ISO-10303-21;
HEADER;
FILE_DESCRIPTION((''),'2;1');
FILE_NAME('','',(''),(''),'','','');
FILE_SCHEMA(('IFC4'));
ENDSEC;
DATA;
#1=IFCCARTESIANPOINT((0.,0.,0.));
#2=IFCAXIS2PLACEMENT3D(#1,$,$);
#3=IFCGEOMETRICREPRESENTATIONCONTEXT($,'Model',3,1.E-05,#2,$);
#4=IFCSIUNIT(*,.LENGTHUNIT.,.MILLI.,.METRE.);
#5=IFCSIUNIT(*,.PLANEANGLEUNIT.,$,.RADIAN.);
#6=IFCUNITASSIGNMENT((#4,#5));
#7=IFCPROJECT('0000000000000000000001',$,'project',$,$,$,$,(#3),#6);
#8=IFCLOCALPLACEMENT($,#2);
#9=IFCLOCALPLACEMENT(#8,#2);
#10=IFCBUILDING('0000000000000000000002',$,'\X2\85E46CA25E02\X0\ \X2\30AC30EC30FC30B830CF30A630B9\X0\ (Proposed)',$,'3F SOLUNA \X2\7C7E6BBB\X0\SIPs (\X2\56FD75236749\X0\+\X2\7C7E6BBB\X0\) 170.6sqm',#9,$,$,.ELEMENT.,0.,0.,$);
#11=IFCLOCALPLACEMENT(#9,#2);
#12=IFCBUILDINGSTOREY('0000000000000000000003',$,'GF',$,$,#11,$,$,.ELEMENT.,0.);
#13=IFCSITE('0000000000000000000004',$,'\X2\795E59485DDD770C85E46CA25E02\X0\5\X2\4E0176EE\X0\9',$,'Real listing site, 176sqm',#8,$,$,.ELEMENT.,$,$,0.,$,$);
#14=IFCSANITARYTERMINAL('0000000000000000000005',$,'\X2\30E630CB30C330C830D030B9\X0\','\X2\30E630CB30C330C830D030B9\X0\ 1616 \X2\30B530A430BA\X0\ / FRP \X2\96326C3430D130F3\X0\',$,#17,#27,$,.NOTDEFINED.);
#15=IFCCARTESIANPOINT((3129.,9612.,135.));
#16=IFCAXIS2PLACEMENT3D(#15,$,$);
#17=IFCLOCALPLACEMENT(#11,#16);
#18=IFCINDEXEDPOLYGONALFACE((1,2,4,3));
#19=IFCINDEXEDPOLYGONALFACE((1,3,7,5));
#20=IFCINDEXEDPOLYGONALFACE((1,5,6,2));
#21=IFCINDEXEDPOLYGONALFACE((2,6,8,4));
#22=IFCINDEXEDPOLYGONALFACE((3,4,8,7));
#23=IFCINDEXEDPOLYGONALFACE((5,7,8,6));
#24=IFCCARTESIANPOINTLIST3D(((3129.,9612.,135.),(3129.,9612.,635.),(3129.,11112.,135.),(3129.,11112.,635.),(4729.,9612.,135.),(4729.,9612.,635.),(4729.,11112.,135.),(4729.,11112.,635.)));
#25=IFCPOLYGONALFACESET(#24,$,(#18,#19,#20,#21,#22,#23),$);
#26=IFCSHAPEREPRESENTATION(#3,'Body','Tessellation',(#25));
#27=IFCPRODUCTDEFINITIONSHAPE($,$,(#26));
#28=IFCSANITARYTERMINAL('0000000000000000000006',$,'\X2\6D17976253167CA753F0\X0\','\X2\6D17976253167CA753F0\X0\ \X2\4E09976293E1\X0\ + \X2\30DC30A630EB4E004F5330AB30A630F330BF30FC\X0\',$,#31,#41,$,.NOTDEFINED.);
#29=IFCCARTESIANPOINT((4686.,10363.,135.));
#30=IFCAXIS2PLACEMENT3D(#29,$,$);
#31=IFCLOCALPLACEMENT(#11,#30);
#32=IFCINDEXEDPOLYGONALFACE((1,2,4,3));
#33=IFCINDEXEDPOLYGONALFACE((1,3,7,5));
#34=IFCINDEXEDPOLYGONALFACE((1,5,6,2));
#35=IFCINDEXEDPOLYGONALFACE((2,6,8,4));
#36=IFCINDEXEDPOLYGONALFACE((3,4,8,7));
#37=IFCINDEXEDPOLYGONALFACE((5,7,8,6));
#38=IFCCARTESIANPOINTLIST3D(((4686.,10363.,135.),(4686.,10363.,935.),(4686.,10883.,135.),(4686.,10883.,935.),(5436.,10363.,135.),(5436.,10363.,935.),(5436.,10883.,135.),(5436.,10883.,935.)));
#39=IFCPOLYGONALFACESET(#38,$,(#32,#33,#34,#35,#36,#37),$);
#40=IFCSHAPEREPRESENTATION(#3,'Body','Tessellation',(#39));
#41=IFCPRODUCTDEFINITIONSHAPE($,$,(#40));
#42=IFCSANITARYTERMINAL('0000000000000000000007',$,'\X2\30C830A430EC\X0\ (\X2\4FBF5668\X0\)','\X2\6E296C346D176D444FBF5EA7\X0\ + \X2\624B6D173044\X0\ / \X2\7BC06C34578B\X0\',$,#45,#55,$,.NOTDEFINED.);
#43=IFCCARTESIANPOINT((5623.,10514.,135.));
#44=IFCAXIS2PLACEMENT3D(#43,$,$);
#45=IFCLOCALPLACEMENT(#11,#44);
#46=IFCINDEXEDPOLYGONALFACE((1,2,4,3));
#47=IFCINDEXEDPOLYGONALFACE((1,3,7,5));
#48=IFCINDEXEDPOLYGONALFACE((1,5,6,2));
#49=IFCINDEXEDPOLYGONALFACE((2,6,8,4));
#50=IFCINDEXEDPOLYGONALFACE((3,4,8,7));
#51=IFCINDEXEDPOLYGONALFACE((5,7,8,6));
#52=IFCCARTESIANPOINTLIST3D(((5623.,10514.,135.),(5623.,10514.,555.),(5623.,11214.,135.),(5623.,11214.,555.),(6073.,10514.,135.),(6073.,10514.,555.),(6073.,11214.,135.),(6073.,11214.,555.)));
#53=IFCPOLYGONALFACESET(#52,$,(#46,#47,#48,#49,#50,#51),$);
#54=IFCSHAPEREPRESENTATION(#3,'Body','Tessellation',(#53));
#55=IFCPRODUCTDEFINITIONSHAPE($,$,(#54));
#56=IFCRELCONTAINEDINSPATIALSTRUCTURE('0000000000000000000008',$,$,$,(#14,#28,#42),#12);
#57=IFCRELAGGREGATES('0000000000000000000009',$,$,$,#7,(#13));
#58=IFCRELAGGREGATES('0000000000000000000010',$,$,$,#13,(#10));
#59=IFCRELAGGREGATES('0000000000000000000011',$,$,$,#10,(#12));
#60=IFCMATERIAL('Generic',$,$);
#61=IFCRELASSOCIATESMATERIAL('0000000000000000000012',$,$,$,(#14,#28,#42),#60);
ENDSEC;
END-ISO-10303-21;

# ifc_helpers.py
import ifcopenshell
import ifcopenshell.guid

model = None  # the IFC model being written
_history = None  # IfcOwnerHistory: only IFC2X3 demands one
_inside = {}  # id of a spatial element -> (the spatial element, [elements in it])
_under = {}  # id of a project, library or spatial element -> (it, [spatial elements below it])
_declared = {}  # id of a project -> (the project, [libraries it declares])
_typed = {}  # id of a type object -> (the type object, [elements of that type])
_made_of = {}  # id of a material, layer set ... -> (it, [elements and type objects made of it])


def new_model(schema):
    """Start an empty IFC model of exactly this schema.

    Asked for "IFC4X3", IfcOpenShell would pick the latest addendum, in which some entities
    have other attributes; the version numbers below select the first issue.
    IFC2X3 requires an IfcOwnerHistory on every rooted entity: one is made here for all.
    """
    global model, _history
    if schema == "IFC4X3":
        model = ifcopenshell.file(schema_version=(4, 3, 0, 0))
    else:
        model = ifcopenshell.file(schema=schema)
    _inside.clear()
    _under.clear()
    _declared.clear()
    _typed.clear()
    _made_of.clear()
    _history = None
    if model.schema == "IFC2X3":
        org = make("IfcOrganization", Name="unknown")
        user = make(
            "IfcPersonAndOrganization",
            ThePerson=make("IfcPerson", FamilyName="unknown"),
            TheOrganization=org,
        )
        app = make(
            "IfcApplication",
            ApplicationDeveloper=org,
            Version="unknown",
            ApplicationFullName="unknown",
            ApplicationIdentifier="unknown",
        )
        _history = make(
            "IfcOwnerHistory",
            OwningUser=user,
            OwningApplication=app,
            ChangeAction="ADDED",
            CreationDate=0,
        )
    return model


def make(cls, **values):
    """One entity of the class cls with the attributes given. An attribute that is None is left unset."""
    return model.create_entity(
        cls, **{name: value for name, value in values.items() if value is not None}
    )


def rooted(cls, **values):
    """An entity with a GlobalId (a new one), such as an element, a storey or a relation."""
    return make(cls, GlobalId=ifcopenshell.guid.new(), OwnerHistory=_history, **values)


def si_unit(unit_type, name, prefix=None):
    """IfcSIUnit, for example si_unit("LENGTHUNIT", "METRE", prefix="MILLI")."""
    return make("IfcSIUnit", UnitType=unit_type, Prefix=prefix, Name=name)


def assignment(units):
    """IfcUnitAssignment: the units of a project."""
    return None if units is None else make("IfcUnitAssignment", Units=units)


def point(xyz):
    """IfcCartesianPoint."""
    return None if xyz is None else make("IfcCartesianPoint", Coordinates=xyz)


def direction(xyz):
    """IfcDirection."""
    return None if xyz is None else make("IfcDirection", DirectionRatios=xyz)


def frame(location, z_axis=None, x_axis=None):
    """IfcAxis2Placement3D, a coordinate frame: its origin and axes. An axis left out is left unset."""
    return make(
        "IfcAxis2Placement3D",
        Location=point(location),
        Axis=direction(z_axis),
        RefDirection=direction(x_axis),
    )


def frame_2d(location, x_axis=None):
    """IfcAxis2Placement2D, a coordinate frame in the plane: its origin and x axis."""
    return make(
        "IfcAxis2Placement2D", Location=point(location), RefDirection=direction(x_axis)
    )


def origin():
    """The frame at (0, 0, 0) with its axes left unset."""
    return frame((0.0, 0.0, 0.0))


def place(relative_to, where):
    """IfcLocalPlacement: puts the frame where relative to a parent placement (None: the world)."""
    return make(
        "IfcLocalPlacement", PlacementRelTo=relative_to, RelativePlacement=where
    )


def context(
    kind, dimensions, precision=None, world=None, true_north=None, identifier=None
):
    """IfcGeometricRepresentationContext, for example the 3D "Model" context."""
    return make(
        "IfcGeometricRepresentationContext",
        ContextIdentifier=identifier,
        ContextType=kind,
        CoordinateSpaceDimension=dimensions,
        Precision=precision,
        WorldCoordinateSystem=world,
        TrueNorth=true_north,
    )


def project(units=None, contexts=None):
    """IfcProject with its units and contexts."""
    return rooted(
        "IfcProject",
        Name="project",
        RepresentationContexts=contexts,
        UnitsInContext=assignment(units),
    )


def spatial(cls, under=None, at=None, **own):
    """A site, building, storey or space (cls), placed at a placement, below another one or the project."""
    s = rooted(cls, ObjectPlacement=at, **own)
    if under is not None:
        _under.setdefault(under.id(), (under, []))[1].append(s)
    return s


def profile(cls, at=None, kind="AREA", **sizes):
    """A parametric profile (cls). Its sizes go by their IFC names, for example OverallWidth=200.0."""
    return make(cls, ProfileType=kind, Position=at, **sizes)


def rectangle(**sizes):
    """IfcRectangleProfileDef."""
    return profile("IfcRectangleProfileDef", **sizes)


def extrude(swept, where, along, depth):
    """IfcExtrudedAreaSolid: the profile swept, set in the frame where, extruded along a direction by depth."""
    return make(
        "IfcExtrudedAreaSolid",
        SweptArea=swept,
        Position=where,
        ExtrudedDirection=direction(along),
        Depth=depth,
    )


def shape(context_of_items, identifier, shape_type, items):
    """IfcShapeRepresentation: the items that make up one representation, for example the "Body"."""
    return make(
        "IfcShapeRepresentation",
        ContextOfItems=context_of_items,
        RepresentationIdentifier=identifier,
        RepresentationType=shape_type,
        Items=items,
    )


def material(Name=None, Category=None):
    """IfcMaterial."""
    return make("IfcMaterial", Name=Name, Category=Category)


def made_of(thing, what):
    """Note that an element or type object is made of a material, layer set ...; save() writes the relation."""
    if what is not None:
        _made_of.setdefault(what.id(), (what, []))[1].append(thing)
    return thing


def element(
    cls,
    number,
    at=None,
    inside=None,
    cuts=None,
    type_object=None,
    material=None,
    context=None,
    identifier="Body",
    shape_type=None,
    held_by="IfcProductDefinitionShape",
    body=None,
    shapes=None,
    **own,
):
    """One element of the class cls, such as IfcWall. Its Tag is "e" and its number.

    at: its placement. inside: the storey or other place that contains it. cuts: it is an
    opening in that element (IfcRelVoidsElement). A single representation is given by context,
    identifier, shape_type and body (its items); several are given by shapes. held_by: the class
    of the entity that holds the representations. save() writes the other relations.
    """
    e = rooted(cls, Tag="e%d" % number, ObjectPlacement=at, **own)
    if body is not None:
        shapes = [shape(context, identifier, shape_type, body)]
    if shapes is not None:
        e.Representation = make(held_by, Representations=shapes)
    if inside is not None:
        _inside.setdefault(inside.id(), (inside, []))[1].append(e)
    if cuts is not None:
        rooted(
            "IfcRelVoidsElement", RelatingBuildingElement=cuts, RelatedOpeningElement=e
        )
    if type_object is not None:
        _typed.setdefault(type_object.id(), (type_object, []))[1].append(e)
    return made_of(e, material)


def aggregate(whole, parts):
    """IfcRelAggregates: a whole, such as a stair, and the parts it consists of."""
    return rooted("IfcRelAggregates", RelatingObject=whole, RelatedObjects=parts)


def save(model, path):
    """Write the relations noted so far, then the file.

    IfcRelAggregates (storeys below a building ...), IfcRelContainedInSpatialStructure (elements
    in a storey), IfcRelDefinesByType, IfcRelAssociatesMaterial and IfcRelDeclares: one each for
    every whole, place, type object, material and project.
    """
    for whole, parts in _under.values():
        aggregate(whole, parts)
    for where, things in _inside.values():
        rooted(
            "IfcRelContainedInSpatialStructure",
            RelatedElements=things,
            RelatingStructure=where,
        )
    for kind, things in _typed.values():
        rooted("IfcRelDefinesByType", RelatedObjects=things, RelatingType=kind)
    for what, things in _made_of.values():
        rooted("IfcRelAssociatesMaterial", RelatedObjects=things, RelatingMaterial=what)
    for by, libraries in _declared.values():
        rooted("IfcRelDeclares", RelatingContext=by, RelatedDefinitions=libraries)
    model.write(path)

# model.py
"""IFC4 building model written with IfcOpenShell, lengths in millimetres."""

from ifc_helpers import new_model, si_unit, frame, frame_2d, origin, place, context, project, spatial, rectangle, extrude, material, element, save


model = new_model("IFC4")

# Units and contexts
model_context = context("Model", 3, precision=1e-05, world=origin())
ifc_project = project(units=[si_unit("LENGTHUNIT", "METRE", prefix="MILLI"), si_unit("PLANEANGLEUNIT", "RADIAN")], contexts=[model_context])

# Site, building, storey
site_placement = place(None, origin())
site = spatial("IfcSite", under=ifc_project, at=site_placement, Name="神奈川県藤沢市5丁目9", ObjectType="Real listing site, 176sqm", CompositionType="ELEMENT", RefElevation=0.0)
building_placement = place(site_placement, origin())
building = spatial("IfcBuilding", under=site, at=building_placement, Name="藤沢市 ガレージハウス (Proposed)", ObjectType="3F SOLUNA 籾殻SIPs (国産杉+籾殻) 170.6sqm", CompositionType="ELEMENT", ElevationOfRefHeight=0.0, ElevationOfTerrain=0.0)
storey_placement = place(building_placement, origin())
storey = spatial("IfcBuildingStorey", under=building, at=storey_placement, Name="GF", CompositionType="ELEMENT", Elevation=0.0)

# Shared definitions
ifc_material_1 = material(Name="Generic")

# Sanitary terminals
sanitary_terminal_1_placement = place(storey_placement, frame((3129.0, 9612.0, 135.0)))
element("IfcSanitaryTerminal", 1, at=sanitary_terminal_1_placement, inside=storey, material=ifc_material_1, Name="ユニットバス", Description="ユニットバス 1616 サイズ / FRP 防水パン", PredefinedType="NOTDEFINED", context=model_context, shape_type="SweptSolid", body=[
    extrude(rectangle(XDim=1600.0, YDim=1500.0, at=frame_2d((800.0, 750.0))), frame((3129.0, 9612.0, 135.0)), (0.0, 0.0, 1.0), 500.0),
])
sanitary_terminal_2_placement = place(storey_placement, frame((4686.0, 10363.0, 135.0)))
element("IfcSanitaryTerminal", 2, at=sanitary_terminal_2_placement, inside=storey, material=ifc_material_1, Name="洗面化粧台", Description="洗面化粧台 三面鏡 + ボウル一体カウンター", PredefinedType="NOTDEFINED", context=model_context, shape_type="SweptSolid", body=[
    extrude(rectangle(XDim=750.0, YDim=520.0, at=frame_2d((375.0, 260.0))), frame((4686.0, 10363.0, 135.0)), (0.0, 0.0, 1.0), 800.0),
])
sanitary_terminal_3_placement = place(storey_placement, frame((5623.0, 10514.0, 135.0)))
element("IfcSanitaryTerminal", 3, at=sanitary_terminal_3_placement, inside=storey, material=ifc_material_1, Name="トイレ (便器)", Description="温水洗浄便座 + 手洗い / 節水型", PredefinedType="NOTDEFINED", context=model_context, shape_type="SweptSolid", body=[
    extrude(rectangle(XDim=450.0, YDim=700.0, at=frame_2d((225.0, 350.0))), frame((5623.0, 10514.0, 135.0)), (0.0, 0.0, 1.0), 420.0),
])

save(model, "model.ifc")
